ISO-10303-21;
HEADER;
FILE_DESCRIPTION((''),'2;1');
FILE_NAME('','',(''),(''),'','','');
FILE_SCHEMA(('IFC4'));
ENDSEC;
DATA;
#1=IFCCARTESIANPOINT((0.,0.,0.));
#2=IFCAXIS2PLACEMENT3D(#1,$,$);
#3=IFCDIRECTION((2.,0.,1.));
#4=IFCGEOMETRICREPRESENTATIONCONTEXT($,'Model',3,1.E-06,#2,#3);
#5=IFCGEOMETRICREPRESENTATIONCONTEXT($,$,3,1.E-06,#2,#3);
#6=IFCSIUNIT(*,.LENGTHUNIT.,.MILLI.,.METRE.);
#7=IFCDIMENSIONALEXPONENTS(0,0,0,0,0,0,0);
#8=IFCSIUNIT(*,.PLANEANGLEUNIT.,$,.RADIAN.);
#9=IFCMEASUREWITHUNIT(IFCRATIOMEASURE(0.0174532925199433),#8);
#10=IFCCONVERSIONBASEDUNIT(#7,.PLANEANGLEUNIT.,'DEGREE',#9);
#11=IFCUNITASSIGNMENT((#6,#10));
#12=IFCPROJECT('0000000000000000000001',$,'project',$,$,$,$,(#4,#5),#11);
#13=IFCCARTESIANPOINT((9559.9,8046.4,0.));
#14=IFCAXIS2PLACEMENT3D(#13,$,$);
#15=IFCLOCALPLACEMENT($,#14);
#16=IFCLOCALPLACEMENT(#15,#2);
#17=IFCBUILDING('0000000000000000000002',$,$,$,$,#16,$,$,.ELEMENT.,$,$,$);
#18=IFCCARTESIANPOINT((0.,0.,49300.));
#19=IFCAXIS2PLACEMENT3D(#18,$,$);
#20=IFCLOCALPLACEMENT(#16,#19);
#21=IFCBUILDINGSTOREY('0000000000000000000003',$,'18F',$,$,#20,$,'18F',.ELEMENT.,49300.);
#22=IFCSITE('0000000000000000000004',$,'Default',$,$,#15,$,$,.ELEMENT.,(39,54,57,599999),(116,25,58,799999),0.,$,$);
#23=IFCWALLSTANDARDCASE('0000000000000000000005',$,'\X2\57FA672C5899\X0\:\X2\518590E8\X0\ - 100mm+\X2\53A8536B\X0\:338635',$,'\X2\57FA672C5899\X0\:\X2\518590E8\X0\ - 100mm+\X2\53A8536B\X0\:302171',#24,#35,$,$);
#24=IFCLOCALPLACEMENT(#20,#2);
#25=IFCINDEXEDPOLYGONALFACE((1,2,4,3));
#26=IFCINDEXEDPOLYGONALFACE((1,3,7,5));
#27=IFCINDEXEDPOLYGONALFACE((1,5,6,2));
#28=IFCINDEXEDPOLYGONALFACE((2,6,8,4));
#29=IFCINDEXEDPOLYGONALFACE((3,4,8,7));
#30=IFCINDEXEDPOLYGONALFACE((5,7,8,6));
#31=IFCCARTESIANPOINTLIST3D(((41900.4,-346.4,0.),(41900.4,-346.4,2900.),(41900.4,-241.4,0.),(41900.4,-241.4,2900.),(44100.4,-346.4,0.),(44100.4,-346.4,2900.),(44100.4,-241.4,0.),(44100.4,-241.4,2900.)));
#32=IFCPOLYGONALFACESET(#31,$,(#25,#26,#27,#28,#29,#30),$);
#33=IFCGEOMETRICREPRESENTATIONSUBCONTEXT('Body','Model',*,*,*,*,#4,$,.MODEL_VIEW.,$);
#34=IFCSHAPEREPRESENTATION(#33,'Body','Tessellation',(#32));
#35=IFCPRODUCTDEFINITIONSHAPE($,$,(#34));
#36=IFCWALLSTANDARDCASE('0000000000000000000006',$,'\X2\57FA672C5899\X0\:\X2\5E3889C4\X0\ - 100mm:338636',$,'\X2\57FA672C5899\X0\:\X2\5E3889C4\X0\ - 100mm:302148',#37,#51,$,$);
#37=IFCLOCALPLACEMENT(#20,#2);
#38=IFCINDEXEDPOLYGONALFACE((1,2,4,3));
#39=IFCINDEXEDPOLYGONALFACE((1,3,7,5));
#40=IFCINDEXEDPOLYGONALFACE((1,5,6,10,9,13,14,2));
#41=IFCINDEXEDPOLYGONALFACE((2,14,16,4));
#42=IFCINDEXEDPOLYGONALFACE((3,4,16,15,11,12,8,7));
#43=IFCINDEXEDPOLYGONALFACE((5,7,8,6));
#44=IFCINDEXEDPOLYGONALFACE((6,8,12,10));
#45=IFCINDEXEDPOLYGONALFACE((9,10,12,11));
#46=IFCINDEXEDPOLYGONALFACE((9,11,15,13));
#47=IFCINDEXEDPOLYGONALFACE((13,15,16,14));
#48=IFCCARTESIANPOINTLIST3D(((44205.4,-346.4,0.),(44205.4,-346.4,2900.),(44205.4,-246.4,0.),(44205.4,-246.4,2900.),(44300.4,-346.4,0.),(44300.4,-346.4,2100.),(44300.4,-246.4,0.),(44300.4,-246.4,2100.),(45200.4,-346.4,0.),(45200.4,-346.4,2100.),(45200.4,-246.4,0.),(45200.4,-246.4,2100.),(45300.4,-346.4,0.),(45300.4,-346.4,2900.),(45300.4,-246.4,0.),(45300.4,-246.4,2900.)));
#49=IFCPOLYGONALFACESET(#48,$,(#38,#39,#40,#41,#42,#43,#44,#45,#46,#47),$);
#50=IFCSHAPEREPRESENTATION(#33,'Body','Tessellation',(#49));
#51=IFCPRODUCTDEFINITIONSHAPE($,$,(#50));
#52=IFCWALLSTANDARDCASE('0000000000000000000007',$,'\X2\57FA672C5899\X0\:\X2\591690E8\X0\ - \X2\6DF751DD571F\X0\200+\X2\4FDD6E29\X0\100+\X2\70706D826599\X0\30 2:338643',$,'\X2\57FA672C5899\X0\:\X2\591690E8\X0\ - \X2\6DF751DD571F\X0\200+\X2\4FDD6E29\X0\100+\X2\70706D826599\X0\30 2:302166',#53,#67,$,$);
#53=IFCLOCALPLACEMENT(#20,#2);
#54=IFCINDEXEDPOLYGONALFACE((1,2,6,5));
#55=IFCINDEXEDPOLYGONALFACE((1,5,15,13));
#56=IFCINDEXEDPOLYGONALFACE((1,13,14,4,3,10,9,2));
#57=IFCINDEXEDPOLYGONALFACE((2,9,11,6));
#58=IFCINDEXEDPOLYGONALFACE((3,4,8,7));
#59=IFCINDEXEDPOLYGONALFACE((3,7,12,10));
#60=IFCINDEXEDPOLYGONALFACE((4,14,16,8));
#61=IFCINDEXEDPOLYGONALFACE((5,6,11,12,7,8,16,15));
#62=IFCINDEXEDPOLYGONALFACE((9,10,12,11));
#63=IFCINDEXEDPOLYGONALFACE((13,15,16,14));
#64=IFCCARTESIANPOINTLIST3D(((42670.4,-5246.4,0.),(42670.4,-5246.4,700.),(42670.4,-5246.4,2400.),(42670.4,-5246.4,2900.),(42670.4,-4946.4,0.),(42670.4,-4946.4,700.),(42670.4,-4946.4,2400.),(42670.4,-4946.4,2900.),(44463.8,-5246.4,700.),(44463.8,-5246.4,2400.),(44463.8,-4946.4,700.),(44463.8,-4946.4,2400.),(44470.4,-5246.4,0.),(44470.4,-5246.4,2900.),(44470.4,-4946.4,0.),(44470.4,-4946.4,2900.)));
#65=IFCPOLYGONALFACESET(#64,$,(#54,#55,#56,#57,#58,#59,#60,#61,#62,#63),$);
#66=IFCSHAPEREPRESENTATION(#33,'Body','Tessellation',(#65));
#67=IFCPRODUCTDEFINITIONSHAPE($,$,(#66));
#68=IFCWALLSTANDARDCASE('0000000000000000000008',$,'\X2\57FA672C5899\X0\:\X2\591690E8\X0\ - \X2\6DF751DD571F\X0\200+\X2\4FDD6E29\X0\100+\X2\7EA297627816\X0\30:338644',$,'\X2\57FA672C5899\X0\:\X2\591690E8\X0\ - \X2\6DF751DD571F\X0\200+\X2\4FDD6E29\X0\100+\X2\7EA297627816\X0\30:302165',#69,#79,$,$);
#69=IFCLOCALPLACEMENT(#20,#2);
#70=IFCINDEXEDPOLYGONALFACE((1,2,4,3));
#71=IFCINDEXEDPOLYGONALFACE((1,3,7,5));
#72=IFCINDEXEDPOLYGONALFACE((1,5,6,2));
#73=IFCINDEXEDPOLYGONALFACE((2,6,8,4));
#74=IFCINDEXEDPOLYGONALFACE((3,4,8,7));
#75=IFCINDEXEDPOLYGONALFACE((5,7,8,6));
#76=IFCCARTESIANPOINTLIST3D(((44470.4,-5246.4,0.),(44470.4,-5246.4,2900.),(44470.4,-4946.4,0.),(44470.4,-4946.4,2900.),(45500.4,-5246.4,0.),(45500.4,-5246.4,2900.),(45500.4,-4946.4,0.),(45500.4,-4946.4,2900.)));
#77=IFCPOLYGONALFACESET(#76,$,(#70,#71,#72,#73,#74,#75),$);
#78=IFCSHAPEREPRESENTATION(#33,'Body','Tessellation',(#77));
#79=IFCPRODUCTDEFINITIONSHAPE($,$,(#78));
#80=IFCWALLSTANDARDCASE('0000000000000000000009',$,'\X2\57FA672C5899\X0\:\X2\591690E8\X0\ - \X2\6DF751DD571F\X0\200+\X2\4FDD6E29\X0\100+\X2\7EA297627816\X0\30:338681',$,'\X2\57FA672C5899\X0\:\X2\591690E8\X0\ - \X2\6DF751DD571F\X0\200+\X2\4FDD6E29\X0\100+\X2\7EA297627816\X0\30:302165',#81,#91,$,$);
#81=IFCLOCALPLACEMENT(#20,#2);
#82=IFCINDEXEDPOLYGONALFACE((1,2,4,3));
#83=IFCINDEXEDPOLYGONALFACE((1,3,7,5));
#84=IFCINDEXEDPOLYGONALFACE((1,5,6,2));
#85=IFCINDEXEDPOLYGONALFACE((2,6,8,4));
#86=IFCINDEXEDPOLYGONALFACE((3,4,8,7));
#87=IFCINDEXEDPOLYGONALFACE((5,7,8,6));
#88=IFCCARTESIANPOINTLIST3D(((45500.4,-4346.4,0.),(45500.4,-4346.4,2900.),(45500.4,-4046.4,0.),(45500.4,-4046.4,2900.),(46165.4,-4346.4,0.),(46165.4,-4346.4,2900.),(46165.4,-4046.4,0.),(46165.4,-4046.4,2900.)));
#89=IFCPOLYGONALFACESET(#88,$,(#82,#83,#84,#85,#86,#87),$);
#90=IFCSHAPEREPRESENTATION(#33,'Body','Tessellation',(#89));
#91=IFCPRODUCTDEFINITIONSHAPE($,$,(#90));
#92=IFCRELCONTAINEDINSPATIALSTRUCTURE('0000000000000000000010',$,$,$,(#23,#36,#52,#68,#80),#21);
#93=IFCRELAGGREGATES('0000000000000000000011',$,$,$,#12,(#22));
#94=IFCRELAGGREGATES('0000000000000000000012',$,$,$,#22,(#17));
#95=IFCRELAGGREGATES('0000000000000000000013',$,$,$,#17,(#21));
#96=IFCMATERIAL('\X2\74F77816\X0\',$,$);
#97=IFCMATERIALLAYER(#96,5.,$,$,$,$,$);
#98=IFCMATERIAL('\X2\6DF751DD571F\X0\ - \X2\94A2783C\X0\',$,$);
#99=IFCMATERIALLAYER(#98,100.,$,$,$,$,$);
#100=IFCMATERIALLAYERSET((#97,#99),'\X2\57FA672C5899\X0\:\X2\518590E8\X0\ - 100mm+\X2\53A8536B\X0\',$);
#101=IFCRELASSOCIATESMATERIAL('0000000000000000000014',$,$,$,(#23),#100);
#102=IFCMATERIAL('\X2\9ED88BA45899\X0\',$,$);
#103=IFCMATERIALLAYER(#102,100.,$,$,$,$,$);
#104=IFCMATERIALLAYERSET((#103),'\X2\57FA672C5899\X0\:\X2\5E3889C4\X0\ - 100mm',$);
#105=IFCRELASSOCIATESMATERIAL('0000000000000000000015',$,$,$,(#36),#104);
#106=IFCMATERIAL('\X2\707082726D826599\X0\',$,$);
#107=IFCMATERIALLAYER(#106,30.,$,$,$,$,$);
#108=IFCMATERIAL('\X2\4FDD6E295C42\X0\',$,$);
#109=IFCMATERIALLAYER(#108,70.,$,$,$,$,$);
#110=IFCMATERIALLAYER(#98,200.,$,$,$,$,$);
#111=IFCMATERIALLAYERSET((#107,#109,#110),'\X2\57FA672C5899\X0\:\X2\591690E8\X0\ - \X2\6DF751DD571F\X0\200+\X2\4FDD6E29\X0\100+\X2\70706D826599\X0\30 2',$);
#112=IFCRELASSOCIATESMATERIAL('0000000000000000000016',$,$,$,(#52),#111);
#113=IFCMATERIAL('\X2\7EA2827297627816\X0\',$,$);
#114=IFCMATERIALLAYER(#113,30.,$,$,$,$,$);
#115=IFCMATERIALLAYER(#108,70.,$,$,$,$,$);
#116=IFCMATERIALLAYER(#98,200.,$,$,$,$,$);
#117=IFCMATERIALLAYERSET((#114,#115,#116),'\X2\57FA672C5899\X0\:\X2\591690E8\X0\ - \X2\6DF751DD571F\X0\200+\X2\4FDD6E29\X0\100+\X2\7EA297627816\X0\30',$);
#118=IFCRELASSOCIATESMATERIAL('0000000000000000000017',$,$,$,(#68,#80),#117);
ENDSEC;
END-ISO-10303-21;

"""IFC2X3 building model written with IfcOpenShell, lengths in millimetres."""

from ifc_helpers import new_model, entity, si_unit, converted_unit, direction, frame, frame_2d, origin, place, context, subcontext, project, spatial, rectangle, extrude, material, layer, layer_set, layer_usage, element, save


model = new_model("IFC2X3")

# Units and contexts
model_context = context("Model", 3, precision=1e-06, world=origin(), true_north=direction((2.0, 0.0, 1.0)))
context_of_model = context(None, 3, precision=1e-06, world=origin(), true_north=direction((2.0, 0.0, 1.0)))
body_context = subcontext(model_context, "Body", "Model", "MODEL_VIEW")
ifc_project = project(units=[si_unit("LENGTHUNIT", "METRE", prefix="MILLI"), converted_unit("PLANEANGLEUNIT", "DEGREE", entity("IfcRatioMeasure", 0.0174532925199433), si_unit("PLANEANGLEUNIT", "RADIAN"), dimensions=[0, 0, 0, 0, 0, 0, 0])], contexts=[model_context, context_of_model])

# Site, building, storey
site_placement = place(None, frame((9559.9, 8046.4, 0.0)))
site = spatial("IfcSite", under=ifc_project, at=site_placement, Name="Default", CompositionType="ELEMENT", RefLatitude=(39, 54, 57, 599999), RefLongitude=(116, 25, 58, 799999), RefElevation=0.0)
building_placement = place(site_placement, origin())
building = spatial("IfcBuilding", under=site, at=building_placement, CompositionType="ELEMENT")
storey_placement = place(building_placement, frame((0.0, 0.0, 49300.0)))
storey = spatial("IfcBuildingStorey", under=building, at=storey_placement, Name="18F", LongName="18F", CompositionType="ELEMENT", Elevation=49300.0)

# Shared definitions
ifc_material_1 = material(Name="混凝土 - 钢砼")
ifc_material_2 = material(Name="红色面砖")
ifc_layer_1 = layer(ifc_material_2, 30.0)
ifc_material_3 = material(Name="保温层")
ifc_layer_2 = layer(ifc_material_3, 70.0)
ifc_layer_3 = layer(ifc_material_1, 200.0)
ifc_layer_set_1 = layer_set([ifc_layer_1, ifc_layer_2, ifc_layer_3], Name="基本墙:外部 - 混凝土200+保温100+红面砖30")

# Shared definitions
ifc_material_4 = material(Name="默认墙")
ifc_layer_4 = layer(ifc_material_4, 100.0)
ifc_layer_set_2 = layer_set([ifc_layer_4], Name="基本墙:常规 - 100mm")

# Shared definitions
ifc_material_5 = material(Name="瓷砖")
ifc_layer_5 = layer(ifc_material_5, 5.0)
ifc_layer_6 = layer(ifc_material_1, 100.0)
ifc_layer_set_3 = layer_set([ifc_layer_5, ifc_layer_6], Name="基本墙:内部 - 100mm+厨卫")

# Shared definitions
ifc_material_6 = material(Name="灰色涂料")
ifc_layer_7 = layer(ifc_material_6, 30.0)
ifc_layer_8 = layer(ifc_material_3, 70.0)
ifc_layer_9 = layer(ifc_material_1, 200.0)
ifc_layer_set_4 = layer_set([ifc_layer_7, ifc_layer_8, ifc_layer_9], Name="基本墙:外部 - 混凝土200+保温100+灰涂料30 2")

# Wall
ifc_layer_usage_1 = layer_usage(ifc_layer_set_3, "AXIS2", "NEGATIVE", 52.5)
wall_1_placement = place(storey_placement, frame((41900.4, -293.9, 0.0)))
element("IfcWallStandardCase", 1, at=wall_1_placement, inside=storey, material=ifc_layer_usage_1, Name="基本墙:内部 - 100mm+厨卫:338635", ObjectType="基本墙:内部 - 100mm+厨卫:302171", context=body_context, shape_type="SweptSolid", body=[
    extrude(rectangle(XDim=2200.0, YDim=105.0, at=frame_2d((1100.0, 0.0), x_axis=(-1.0, 0.0))), origin(), (0.0, 0.0, 1.0), 2900.0),
])

# Walls, openings
ifc_layer_usage_2 = layer_usage(ifc_layer_set_2, "AXIS2", "NEGATIVE", 50.0)
wall_2_placement = place(storey_placement, frame((44205.4, -296.4, 0.0)))
wall_2 = element("IfcWallStandardCase", 2, at=wall_2_placement, inside=storey, material=ifc_layer_usage_2, Name="基本墙:常规 - 100mm:338636", ObjectType="基本墙:常规 - 100mm:302148", context=body_context, shape_type="SweptSolid", body=[
    extrude(rectangle(XDim=1095.0, YDim=100.0, at=frame_2d((547.5, 0.0), x_axis=(-1.0, 0.0))), origin(), (0.0, 0.0, 1.0), 2900.0),
])
opening_1_placement = place(wall_2_placement, frame((995.0, 50.0, 0.0)))
element("IfcOpeningElement", 3, at=opening_1_placement, cuts=wall_2, ObjectType="Opening", context=body_context, shape_type="SweptSolid", body=[
    extrude(rectangle(XDim=2100.0, YDim=900.0, at=frame_2d((1050.0, 450.0), x_axis=(1.0, 0.0))), frame((0.0, 0.0, 0.0), z_axis=(0.0, -1.0, 0.0), x_axis=(0.0, 0.0, 1.0)), (0.0, 0.0, 1.0), 100.0),
])
ifc_layer_usage_3 = layer_usage(ifc_layer_set_4, "AXIS2", "POSITIVE", -150.0)
wall_3_placement = place(storey_placement, frame((42670.4, -5096.4, 0.0)))
wall_3 = element("IfcWallStandardCase", 4, at=wall_3_placement, inside=storey, material=ifc_layer_usage_3, Name="基本墙:外部 - 混凝土200+保温100+灰涂料30 2:338643", ObjectType="基本墙:外部 - 混凝土200+保温100+灰涂料30 2:302166", context=body_context, shape_type="SweptSolid", body=[
    extrude(rectangle(XDim=1800.0, YDim=300.0, at=frame_2d((900.0, 0.0), x_axis=(-1.0, 0.0))), origin(), (0.0, 0.0, 1.0), 2900.0),
])
opening_2_placement = place(wall_3_placement, frame((1793.4, 150.0, 700.0)))
element("IfcOpeningElement", 5, at=opening_2_placement, cuts=wall_3, ObjectType="Opening", context=body_context, shape_type="SweptSolid", body=[
    extrude(rectangle(XDim=1700.0, YDim=1800.0, at=frame_2d((850.0, 900.0), x_axis=(1.0, 0.0))), frame((0.0, 0.0, 0.0), z_axis=(0.0, -1.0, 0.0), x_axis=(0.0, 0.0, 1.0)), (0.0, 0.0, 1.0), 300.0),
])

# Walls
ifc_layer_usage_4 = layer_usage(ifc_layer_set_1, "AXIS2", "POSITIVE", -150.0)
wall_4_placement = place(storey_placement, frame((44470.4, -5096.4, 0.0)))
element("IfcWallStandardCase", 6, at=wall_4_placement, inside=storey, material=ifc_layer_usage_4, Name="基本墙:外部 - 混凝土200+保温100+红面砖30:338644", ObjectType="基本墙:外部 - 混凝土200+保温100+红面砖30:302165", context=body_context, shape_type="SweptSolid", body=[
    extrude(rectangle(XDim=1030.0, YDim=300.0, at=frame_2d((515.0, 0.0), x_axis=(-1.0, 0.0))), origin(), (0.0, 0.0, 1.0), 2900.0),
])
ifc_layer_usage_5 = layer_usage(ifc_layer_set_1, "AXIS2", "POSITIVE", -150.0)
wall_5_placement = place(storey_placement, frame((45500.4, -4196.4, 0.0)))
element("IfcWallStandardCase", 7, at=wall_5_placement, inside=storey, material=ifc_layer_usage_5, Name="基本墙:外部 - 混凝土200+保温100+红面砖30:338681", ObjectType="基本墙:外部 - 混凝土200+保温100+红面砖30:302165", context=body_context, shape_type="SweptSolid", body=[
    extrude(rectangle(XDim=665.0, YDim=300.0, at=frame_2d((332.5, 0.0), x_axis=(-1.0, 0.0))), origin(), (0.0, 0.0, 1.0), 2900.0),
])

save(model, "model.ifc")
